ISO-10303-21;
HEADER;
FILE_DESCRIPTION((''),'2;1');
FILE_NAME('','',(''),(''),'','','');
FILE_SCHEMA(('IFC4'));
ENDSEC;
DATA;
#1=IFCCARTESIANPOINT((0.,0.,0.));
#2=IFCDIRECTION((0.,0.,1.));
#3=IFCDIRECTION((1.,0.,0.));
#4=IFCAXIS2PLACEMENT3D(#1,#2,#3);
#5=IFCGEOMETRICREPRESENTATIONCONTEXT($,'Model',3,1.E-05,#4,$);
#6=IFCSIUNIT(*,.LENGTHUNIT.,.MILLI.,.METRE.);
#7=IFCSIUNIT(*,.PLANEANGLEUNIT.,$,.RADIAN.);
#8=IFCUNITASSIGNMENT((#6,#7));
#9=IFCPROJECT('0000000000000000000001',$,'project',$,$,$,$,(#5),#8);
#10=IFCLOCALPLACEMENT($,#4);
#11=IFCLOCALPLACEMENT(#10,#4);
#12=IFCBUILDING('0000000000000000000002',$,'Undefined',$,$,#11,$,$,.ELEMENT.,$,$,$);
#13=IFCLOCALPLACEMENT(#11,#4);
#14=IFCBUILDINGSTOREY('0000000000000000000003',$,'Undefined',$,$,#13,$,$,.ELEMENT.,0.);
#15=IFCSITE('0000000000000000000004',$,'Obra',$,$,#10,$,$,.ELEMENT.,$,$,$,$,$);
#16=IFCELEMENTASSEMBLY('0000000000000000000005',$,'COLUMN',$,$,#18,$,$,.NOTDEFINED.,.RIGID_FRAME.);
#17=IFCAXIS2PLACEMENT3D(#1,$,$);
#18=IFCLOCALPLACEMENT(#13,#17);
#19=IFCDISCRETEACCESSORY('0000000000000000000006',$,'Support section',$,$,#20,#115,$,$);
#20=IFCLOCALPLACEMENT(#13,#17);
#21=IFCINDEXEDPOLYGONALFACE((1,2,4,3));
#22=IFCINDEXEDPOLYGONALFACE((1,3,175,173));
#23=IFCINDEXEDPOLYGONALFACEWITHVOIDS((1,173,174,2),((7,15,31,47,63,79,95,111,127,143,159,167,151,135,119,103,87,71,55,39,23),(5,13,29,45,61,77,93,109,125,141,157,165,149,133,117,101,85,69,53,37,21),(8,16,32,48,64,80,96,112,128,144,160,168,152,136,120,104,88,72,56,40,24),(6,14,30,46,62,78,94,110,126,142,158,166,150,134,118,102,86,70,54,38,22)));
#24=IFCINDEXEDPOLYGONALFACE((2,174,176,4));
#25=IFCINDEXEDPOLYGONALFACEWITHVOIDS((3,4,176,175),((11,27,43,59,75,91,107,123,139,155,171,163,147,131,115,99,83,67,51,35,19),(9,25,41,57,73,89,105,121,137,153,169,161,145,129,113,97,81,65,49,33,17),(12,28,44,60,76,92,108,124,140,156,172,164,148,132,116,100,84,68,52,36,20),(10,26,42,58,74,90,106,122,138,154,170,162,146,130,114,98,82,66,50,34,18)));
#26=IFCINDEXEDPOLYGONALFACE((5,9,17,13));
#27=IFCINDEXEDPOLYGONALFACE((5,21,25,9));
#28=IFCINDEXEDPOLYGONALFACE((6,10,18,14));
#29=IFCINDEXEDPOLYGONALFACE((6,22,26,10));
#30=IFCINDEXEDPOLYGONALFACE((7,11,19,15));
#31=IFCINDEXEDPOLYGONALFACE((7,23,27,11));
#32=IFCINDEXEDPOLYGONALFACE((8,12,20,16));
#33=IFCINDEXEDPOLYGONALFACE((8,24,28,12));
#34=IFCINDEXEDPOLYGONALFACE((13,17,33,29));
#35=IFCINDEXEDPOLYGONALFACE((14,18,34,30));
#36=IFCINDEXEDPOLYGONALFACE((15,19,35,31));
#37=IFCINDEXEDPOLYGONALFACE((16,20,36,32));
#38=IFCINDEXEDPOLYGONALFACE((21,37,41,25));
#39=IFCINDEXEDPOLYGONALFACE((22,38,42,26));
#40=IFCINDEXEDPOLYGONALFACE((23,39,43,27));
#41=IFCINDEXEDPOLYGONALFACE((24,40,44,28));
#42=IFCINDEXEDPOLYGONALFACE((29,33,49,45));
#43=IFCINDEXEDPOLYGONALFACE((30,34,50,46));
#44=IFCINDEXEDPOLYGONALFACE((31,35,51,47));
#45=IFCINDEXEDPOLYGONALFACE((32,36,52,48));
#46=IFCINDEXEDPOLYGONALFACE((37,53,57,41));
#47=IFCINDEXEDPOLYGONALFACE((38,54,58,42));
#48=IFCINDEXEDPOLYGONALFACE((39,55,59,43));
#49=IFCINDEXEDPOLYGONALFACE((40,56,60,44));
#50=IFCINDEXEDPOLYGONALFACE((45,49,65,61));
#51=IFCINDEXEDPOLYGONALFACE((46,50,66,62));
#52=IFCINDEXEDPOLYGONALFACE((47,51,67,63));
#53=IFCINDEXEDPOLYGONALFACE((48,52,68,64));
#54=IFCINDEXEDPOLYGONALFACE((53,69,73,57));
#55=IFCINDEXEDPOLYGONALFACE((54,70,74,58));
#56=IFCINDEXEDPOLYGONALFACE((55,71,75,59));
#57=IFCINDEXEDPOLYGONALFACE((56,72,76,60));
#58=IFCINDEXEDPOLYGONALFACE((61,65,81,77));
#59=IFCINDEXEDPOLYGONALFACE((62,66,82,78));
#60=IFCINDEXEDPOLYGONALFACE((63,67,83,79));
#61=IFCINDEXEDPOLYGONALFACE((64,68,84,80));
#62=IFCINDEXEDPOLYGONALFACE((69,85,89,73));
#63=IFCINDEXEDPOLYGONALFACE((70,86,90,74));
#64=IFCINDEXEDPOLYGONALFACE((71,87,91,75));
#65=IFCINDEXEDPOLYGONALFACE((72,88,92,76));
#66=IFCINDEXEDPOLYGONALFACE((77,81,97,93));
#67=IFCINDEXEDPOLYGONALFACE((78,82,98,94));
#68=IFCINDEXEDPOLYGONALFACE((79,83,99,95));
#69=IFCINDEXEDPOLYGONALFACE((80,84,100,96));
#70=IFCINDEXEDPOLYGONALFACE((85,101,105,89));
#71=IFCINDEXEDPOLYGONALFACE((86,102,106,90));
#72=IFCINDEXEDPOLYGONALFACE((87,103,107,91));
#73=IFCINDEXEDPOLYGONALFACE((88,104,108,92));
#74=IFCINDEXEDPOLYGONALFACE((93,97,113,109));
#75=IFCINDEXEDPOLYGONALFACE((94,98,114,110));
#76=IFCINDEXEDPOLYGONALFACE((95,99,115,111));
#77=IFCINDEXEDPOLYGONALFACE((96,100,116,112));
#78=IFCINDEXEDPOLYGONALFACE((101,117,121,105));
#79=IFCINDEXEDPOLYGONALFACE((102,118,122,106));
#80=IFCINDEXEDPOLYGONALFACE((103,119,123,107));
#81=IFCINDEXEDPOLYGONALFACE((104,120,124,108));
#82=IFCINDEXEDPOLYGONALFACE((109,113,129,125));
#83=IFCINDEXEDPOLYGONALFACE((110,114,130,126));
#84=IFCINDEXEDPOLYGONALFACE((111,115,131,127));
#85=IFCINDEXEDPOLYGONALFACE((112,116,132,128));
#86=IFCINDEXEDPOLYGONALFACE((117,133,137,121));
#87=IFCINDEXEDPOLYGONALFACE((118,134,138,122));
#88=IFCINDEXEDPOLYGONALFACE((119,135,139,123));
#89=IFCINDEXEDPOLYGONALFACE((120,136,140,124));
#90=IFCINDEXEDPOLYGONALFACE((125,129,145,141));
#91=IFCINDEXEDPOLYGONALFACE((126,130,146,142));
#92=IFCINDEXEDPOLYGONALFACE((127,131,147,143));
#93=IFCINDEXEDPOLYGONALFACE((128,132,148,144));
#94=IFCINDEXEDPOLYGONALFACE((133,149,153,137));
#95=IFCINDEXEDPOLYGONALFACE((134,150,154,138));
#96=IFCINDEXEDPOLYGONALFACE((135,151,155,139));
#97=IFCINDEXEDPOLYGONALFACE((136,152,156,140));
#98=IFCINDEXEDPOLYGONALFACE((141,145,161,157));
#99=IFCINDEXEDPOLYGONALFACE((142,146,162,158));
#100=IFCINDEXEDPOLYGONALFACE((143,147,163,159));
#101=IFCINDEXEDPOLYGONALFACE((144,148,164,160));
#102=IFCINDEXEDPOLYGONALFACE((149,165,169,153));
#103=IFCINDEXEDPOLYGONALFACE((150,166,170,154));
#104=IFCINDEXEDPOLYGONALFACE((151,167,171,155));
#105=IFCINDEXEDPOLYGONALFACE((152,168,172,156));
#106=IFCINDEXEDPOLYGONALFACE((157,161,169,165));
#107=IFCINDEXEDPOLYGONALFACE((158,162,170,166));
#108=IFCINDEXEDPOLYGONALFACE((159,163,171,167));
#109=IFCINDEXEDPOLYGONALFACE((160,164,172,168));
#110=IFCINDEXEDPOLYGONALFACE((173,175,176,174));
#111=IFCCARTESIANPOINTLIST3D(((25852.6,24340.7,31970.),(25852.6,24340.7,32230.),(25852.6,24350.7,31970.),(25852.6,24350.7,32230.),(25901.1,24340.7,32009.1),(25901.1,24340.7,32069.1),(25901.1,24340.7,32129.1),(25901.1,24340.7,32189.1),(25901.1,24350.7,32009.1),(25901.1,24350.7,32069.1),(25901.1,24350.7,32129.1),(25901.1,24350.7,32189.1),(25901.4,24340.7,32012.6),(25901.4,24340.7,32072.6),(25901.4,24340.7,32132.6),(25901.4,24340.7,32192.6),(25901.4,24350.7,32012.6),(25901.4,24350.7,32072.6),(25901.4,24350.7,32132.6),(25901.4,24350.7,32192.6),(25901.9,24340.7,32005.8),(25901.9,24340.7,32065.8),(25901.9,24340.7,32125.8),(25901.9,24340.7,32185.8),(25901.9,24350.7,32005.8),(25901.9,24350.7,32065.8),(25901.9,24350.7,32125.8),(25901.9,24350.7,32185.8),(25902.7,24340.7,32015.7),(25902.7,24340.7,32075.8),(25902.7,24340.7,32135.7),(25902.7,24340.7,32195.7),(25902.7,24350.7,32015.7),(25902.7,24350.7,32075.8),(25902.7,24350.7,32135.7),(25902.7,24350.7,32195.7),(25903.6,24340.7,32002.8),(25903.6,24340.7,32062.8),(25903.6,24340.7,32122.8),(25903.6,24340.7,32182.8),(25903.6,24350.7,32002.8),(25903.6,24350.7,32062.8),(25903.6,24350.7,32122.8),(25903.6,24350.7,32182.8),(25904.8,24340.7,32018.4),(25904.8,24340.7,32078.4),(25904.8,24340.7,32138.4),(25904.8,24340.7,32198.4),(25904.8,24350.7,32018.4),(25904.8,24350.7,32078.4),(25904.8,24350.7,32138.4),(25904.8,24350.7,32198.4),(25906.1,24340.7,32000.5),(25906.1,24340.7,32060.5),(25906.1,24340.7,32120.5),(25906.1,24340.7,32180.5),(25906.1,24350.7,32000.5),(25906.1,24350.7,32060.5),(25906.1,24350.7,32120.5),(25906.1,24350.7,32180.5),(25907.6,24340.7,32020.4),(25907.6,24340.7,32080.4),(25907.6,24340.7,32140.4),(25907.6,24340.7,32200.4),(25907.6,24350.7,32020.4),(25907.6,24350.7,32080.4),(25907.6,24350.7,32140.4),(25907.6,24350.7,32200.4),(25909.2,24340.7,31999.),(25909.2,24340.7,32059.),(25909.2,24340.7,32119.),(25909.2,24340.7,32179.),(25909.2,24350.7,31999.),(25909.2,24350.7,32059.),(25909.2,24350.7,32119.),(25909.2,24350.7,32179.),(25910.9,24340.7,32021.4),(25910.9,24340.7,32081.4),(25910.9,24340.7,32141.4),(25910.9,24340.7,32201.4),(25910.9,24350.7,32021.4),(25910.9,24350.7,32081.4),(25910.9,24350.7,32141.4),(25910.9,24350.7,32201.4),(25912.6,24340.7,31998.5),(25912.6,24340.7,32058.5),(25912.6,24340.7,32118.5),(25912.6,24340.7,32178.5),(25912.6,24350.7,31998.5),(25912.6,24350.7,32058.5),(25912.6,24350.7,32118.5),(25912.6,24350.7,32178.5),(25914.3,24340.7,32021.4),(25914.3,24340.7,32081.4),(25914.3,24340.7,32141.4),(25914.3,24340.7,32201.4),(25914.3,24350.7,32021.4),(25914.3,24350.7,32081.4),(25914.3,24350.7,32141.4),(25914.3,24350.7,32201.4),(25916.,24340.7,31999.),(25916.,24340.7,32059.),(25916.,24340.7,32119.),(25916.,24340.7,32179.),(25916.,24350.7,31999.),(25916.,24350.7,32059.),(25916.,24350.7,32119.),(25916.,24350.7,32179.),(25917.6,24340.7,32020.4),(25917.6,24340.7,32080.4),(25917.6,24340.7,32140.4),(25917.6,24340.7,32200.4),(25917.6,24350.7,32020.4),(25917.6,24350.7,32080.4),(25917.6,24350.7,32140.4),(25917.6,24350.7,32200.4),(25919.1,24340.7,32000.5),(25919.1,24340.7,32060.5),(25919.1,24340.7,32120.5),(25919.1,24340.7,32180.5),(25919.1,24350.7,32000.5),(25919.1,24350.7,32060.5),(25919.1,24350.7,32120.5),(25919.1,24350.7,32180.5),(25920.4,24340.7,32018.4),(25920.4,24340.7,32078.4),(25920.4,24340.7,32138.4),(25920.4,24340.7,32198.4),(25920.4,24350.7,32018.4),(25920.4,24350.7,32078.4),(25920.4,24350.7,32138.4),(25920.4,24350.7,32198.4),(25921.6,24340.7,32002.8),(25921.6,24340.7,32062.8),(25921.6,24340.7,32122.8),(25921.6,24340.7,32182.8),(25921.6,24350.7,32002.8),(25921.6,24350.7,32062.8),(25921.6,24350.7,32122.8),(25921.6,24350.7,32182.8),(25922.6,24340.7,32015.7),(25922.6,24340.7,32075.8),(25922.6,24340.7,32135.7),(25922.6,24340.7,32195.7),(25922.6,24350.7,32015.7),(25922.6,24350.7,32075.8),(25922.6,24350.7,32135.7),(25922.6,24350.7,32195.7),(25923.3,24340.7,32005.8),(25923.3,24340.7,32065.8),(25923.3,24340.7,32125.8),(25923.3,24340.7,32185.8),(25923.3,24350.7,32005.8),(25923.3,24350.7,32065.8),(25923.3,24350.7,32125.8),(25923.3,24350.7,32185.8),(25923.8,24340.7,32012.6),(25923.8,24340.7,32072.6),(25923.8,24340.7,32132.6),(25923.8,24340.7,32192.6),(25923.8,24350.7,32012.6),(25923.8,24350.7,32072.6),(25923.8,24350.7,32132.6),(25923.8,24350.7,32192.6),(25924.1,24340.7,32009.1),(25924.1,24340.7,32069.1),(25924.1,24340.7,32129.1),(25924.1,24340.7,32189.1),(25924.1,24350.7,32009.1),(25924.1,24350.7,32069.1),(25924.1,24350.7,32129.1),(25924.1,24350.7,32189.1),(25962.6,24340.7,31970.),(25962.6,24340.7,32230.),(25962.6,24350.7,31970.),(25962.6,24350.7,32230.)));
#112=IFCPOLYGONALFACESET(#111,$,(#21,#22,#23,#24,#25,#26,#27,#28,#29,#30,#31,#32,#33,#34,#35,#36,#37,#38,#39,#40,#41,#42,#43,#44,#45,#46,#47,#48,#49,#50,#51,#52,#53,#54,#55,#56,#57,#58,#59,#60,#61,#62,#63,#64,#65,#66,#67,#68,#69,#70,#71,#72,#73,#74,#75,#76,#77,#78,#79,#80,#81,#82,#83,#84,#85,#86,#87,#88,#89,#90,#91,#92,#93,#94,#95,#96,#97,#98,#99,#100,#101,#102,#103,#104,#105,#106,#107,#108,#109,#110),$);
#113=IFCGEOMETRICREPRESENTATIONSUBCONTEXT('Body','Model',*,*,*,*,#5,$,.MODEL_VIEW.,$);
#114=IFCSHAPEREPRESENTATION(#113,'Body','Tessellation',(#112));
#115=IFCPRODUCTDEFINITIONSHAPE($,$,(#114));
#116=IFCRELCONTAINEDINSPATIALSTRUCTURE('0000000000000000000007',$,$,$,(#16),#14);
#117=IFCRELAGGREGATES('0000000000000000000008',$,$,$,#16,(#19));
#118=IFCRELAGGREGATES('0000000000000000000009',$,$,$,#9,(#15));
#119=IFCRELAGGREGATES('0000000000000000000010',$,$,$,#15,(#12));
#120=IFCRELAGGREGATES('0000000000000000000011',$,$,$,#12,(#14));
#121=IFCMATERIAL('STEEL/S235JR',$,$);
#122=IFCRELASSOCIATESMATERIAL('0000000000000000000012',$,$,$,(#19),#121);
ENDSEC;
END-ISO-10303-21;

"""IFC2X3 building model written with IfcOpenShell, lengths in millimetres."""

from ifc_helpers import new_model, si_unit, frame, origin_with_axes, origin_2d_with_axis, place, context, subcontext, project, spatial, rectangle, circle, extrude, source, transform, mapped, material, element, aggregate, save


model = new_model("IFC2X3")

# Units and contexts
model_context = context("Model", 3, precision=1e-05, world=origin_with_axes())
body_context = subcontext(model_context, "Body", "Model", "MODEL_VIEW")
ifc_project = project(units=[si_unit("LENGTHUNIT", "METRE", prefix="MILLI"), si_unit("PLANEANGLEUNIT", "RADIAN")], contexts=[model_context])

# Site, building, storey
site_placement = place(None, origin_with_axes())
site = spatial("IfcSite", under=ifc_project, at=site_placement, Name="Obra", CompositionType="ELEMENT")
building_placement = place(site_placement, origin_with_axes())
building = spatial("IfcBuilding", under=site, at=building_placement, Name="Undefined", CompositionType="ELEMENT")
storey_placement = place(building_placement, origin_with_axes())
storey = spatial("IfcBuildingStorey", under=building, at=storey_placement, Name="Undefined", CompositionType="ELEMENT", Elevation=0.0)

# Shared definitions
ifc_material_1 = material(Name="STEEL/S235JR")

# Element assembly
assembly_1_placement = place(storey_placement, origin_with_axes())
assembly_1 = element("IfcElementAssembly", 1, at=assembly_1_placement, inside=storey, Name="COLUMN", AssemblyPlace="NOTDEFINED", PredefinedType="RIGID_FRAME")
shared_shape_1 = source(origin_with_axes(), body_context, "Body", "SweptSolid", [
    extrude(circle(Radius=11.5, at=origin_2d_with_axis()), frame((0.0, -14.4, 0.0), z_axis=(0.0, 1.0, 0.0), x_axis=(1.0, 0.0, 0.0)), (0.0, 0.0, 1.0), 10.2),
])

# Discrete accessory, opening
discrete_accessory_1_placement = place(assembly_1_placement, frame((25907.6, 24345.7, 31970.0), z_axis=(0.0, 0.0, 1.0), x_axis=(-1.0, 0.0, 0.0)))
discrete_accessory_1 = element("IfcDiscreteAccessory", 2, at=discrete_accessory_1_placement, material=ifc_material_1, Name="Support section", context=body_context, shape_type="SweptSolid", body=[
    extrude(rectangle(XDim=10.0, YDim=110.0, at=origin_2d_with_axis()), frame((0.0, 0.0, 260.0), z_axis=(0.0, 0.0, -1.0), x_axis=(0.0, 1.0, 0.0)), (0.0, 0.0, 1.0), 260.0),
])
opening_1_placement = place(assembly_1_placement, frame((25862.6, 24355.0, 32300.0), z_axis=(1.0, 0.0, 0.0), x_axis=(0.0, 0.0, -1.0)))
element("IfcOpeningElement", 3, at=opening_1_placement, cuts=discrete_accessory_1, ObjectType="Opening", context=body_context, shape_type="MappedRepresentation", body=[
    mapped(shared_shape_1, transform((110.0, 0.0, 50.0))),
    mapped(shared_shape_1, transform((170.0, 0.0, 50.0))),
    mapped(shared_shape_1, transform((230.0, 0.0, 50.0))),
    mapped(shared_shape_1, transform((290.0, 0.0, 50.0))),
])

aggregate(assembly_1, [discrete_accessory_1])

save(model, "model.ifc")
